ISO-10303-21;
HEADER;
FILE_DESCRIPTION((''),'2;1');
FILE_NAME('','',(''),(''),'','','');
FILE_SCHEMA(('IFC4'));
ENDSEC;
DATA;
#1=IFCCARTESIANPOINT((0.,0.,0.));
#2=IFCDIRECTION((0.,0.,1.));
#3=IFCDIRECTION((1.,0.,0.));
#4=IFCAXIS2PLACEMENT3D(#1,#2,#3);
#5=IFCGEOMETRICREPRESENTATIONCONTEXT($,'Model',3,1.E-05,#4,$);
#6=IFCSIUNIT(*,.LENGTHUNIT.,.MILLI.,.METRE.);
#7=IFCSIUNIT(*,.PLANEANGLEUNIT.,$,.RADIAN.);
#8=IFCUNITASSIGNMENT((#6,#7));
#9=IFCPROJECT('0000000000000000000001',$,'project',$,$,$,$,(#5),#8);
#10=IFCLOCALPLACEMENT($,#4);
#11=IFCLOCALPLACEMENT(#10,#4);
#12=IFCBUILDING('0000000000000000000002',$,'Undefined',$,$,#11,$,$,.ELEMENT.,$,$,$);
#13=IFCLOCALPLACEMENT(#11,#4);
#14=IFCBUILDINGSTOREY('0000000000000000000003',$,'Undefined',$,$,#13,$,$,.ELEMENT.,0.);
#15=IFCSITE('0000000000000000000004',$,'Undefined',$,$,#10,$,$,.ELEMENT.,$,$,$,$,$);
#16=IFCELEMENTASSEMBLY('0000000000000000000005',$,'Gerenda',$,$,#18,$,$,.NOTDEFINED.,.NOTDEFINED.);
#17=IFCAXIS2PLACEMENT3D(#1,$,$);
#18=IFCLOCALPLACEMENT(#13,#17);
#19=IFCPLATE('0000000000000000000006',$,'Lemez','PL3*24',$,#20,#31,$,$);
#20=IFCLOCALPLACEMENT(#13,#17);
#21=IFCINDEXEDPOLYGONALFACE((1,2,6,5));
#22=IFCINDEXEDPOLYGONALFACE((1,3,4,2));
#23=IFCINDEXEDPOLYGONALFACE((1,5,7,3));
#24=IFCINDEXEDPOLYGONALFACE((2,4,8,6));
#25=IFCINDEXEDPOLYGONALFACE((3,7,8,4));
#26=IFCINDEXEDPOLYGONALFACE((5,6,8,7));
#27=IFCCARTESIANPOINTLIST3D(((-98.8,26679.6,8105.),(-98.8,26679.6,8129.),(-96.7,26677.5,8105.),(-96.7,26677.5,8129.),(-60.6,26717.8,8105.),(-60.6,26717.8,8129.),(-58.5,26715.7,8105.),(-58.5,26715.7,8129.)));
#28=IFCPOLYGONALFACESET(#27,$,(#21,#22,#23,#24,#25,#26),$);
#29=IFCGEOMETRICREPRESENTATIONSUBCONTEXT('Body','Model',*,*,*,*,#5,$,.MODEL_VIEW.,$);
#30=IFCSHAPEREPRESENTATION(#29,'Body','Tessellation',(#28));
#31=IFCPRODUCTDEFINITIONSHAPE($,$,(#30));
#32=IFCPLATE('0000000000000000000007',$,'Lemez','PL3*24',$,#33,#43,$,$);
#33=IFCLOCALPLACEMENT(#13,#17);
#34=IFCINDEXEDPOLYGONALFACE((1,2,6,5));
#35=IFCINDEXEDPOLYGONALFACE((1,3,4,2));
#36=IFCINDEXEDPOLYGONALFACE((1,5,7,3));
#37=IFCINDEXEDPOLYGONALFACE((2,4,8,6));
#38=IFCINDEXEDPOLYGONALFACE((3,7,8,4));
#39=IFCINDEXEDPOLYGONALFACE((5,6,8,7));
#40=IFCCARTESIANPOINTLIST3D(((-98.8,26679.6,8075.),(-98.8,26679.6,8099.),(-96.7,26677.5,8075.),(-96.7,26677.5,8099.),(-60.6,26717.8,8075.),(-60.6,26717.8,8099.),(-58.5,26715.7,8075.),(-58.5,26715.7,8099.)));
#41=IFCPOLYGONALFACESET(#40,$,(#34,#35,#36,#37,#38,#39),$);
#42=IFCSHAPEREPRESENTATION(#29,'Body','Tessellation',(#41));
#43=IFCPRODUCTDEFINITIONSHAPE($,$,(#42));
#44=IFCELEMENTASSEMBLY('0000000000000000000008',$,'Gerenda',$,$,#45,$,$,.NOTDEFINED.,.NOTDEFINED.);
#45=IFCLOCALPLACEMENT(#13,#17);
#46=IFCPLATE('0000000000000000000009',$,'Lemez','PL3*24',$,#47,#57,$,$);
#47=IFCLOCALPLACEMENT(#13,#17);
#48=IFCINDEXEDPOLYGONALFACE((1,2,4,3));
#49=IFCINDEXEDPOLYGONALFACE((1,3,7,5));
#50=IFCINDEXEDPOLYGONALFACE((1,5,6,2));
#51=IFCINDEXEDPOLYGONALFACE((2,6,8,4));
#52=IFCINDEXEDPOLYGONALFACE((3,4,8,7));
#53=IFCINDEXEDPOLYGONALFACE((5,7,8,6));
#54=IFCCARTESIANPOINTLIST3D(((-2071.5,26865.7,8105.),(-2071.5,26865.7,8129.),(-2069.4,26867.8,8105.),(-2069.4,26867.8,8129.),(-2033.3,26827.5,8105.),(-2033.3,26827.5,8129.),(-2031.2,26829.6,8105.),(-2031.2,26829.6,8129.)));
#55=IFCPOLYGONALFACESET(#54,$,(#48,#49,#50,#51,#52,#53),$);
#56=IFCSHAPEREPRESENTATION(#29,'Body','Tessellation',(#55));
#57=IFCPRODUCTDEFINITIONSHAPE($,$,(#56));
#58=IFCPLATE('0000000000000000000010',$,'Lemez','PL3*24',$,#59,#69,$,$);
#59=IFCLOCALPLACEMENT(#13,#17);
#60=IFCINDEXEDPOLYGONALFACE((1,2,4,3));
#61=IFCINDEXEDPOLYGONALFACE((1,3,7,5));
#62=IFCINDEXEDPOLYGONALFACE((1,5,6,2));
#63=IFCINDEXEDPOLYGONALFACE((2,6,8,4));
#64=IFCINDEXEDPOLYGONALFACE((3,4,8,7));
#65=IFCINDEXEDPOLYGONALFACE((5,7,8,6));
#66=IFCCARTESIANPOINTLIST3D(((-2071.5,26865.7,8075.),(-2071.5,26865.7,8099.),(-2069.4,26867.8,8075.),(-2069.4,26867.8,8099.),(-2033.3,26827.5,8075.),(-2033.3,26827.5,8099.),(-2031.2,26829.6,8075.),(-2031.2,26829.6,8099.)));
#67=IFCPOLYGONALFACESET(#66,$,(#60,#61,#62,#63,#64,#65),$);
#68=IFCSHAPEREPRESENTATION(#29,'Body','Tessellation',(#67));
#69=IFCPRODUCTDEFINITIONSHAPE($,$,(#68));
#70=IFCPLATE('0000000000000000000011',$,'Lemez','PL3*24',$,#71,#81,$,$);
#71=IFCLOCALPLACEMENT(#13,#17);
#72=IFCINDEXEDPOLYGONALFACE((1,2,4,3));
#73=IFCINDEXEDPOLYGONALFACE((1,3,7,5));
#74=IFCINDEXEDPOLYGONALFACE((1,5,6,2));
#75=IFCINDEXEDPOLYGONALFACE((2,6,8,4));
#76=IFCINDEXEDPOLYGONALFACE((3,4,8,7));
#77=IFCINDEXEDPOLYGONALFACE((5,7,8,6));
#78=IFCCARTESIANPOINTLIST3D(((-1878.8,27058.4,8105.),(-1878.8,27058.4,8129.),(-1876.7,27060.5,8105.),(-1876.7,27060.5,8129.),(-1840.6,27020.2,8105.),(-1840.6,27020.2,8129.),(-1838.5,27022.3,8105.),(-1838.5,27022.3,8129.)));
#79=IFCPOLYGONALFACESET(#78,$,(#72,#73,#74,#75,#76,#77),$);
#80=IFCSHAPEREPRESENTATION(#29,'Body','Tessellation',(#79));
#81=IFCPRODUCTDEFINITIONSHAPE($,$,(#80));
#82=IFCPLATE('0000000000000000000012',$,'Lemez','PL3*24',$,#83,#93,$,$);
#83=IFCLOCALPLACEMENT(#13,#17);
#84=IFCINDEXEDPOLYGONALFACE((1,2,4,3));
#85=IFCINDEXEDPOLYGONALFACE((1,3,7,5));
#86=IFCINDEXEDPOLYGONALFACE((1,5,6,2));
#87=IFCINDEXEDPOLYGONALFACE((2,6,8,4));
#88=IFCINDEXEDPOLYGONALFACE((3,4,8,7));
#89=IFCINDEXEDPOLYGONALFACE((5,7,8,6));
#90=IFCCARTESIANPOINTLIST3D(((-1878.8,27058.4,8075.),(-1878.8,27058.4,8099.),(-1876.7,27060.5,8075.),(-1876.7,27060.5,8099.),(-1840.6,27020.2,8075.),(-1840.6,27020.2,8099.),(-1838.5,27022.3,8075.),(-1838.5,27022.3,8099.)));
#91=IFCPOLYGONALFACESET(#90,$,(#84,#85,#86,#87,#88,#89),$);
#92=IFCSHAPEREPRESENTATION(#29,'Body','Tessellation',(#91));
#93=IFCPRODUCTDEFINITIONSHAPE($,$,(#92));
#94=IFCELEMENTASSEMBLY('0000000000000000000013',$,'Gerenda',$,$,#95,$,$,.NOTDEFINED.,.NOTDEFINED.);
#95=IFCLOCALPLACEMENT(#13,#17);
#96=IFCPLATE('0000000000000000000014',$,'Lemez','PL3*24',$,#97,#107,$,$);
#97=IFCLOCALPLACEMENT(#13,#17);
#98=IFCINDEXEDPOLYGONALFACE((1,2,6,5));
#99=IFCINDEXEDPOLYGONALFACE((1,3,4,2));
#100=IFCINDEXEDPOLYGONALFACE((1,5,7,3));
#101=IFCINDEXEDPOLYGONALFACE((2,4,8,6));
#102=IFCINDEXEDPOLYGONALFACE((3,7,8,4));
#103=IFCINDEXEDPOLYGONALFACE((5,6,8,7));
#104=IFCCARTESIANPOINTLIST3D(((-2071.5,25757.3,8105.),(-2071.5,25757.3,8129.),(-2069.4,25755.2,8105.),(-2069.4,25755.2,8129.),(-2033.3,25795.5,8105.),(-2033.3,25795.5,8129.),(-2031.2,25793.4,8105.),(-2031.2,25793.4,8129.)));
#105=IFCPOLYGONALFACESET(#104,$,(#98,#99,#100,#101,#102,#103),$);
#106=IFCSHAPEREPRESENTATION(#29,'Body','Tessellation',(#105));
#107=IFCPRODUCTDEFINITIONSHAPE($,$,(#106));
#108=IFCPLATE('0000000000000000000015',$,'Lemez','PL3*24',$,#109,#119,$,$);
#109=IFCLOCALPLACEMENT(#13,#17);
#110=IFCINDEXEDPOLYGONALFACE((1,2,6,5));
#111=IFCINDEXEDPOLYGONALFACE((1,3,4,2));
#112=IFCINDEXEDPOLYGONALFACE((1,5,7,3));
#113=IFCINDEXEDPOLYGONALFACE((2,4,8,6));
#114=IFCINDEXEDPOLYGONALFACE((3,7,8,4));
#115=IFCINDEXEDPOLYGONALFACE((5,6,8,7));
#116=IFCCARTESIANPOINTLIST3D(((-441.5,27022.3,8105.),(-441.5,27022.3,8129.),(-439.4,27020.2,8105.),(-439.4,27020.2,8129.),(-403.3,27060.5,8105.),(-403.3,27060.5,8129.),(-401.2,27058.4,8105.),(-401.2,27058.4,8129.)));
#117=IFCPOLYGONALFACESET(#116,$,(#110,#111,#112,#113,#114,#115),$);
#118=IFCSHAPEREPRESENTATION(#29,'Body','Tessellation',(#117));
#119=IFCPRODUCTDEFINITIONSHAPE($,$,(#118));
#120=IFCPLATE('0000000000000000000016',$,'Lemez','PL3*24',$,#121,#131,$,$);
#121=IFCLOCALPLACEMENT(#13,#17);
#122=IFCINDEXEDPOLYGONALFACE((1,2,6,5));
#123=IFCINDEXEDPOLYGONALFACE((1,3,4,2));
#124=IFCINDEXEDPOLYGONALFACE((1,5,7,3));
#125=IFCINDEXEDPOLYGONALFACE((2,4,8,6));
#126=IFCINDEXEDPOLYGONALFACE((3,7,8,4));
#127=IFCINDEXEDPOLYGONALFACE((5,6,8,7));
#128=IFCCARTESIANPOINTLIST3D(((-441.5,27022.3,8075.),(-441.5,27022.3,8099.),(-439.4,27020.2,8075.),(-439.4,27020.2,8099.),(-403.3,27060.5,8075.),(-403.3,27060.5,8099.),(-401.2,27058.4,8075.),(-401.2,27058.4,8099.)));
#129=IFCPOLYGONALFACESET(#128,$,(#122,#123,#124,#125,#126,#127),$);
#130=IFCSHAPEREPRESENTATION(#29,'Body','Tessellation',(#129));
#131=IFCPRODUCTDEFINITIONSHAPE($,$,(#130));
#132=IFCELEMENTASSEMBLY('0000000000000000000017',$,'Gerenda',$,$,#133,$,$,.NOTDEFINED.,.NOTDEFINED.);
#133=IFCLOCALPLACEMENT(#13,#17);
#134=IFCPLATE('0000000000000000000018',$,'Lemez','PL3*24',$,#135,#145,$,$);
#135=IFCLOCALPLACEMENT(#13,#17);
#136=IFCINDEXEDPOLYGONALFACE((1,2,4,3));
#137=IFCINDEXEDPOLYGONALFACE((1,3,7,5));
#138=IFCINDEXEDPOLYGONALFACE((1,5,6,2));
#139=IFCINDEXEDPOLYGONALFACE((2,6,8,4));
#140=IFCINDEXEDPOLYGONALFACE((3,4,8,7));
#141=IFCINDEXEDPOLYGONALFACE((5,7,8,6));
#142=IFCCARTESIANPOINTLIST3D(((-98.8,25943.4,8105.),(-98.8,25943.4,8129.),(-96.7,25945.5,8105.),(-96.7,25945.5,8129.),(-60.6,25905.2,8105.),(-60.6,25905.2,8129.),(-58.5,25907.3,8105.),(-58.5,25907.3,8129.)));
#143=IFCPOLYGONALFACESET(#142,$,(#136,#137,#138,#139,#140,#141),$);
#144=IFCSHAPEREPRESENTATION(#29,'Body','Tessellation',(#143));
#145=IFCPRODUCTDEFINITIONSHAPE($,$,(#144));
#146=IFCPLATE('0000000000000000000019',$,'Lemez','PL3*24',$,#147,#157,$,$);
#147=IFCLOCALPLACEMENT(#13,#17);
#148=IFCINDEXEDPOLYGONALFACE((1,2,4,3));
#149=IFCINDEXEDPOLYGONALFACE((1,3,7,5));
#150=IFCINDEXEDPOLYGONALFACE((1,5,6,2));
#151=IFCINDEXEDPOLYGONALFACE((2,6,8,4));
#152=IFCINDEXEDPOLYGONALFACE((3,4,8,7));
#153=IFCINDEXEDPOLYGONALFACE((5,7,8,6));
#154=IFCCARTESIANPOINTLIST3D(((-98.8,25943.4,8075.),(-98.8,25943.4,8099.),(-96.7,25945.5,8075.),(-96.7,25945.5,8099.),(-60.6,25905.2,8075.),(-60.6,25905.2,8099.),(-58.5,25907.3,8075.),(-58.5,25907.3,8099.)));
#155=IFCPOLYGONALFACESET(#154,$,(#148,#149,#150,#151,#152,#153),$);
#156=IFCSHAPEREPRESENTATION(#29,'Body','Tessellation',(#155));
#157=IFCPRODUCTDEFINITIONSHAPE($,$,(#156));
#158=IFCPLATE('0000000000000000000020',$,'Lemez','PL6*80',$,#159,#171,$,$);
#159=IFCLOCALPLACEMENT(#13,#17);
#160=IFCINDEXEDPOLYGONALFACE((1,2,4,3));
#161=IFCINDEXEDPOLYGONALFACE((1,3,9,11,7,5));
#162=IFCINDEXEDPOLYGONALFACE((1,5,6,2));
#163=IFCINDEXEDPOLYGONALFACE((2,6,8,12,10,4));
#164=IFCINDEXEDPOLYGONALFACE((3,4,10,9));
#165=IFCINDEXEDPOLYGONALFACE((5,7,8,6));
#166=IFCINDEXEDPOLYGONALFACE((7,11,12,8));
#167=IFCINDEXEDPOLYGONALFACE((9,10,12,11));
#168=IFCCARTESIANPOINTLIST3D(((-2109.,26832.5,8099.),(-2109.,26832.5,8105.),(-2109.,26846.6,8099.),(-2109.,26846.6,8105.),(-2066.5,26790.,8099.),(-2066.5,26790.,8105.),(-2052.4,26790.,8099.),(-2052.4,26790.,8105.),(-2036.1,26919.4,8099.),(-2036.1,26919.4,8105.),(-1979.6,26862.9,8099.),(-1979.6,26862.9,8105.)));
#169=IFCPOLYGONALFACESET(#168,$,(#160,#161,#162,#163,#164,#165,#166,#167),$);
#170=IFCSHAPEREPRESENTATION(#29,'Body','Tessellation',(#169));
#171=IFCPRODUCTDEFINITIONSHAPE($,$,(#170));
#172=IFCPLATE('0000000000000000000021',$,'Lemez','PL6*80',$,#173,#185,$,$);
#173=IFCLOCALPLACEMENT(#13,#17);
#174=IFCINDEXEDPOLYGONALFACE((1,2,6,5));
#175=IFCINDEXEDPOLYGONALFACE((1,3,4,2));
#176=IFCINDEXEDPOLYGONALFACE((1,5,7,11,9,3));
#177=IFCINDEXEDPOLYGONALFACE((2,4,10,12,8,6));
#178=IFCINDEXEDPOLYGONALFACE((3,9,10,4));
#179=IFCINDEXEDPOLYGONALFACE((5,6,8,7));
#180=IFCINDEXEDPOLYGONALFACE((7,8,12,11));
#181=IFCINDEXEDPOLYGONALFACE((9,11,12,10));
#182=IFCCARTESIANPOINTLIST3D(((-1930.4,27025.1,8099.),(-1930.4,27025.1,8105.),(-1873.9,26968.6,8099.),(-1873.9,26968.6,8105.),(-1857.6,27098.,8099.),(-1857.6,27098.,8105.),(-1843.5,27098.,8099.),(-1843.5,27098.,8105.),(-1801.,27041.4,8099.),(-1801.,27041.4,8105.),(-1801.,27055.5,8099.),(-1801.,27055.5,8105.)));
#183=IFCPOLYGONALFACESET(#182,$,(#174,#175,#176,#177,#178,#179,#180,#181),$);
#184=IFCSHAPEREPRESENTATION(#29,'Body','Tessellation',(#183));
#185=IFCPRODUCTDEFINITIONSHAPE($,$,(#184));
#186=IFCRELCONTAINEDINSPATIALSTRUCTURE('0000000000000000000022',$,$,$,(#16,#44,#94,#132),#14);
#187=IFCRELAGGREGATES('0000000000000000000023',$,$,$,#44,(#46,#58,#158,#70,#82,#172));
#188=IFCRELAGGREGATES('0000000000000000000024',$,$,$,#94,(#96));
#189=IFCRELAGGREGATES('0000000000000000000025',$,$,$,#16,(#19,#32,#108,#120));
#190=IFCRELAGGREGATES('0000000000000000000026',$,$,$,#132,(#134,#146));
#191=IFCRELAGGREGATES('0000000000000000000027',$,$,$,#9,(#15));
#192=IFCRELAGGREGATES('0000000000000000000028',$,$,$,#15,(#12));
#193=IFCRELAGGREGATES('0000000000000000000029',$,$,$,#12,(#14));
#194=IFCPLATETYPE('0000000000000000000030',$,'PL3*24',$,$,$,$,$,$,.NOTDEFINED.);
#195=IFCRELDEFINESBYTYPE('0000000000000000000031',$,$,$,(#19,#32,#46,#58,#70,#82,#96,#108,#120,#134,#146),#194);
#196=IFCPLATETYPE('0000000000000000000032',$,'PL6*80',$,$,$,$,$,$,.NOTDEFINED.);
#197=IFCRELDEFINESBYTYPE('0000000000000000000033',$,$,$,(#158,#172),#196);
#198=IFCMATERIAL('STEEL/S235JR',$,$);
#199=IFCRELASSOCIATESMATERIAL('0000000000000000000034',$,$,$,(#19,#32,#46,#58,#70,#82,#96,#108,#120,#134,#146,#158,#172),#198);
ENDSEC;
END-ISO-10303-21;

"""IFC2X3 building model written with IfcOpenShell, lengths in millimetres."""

from ifc_helpers import new_model, si_unit, frame, origin_with_axes, place, context, subcontext, project, spatial, polyline, outline, extrude, material, type_object, element, aggregate, save


model = new_model("IFC2X3")

# Units and contexts
model_context = context("Model", 3, precision=1e-05, world=origin_with_axes())
body_context = subcontext(model_context, "Body", "Model", "MODEL_VIEW")
ifc_project = project(units=[si_unit("LENGTHUNIT", "METRE", prefix="MILLI"), si_unit("PLANEANGLEUNIT", "RADIAN")], contexts=[model_context])

# Site, building, storey
site_placement = place(None, origin_with_axes())
site = spatial("IfcSite", under=ifc_project, at=site_placement, Name="Undefined", CompositionType="ELEMENT")
building_placement = place(site_placement, origin_with_axes())
building = spatial("IfcBuilding", under=site, at=building_placement, Name="Undefined", CompositionType="ELEMENT")
storey_placement = place(building_placement, origin_with_axes())
storey = spatial("IfcBuildingStorey", under=building, at=storey_placement, Name="Undefined", CompositionType="ELEMENT", Elevation=0.0)

# Element assemblies, plates
assembly_1_placement = place(storey_placement, origin_with_axes())
assembly_1 = element("IfcElementAssembly", 1, at=assembly_1_placement, inside=storey, Name="Gerenda", AssemblyPlace="NOTDEFINED", PredefinedType="NOTDEFINED")
ifc_material_1 = material(Name="STEEL/S235JR")
plate_type_1 = type_object("IfcPlateType", Name="PL3*24", PredefinedType="NOTDEFINED")
plate_1_placement = place(assembly_1_placement, frame((-59.6, 26716.7, 8129.0), z_axis=(-0.707112, 0.707102, 0.0), x_axis=(0.0, 0.0, -1.0)))
plate_1 = element("IfcPlate", 2, at=plate_1_placement, type_object=plate_type_1, material=ifc_material_1, Name="Lemez", Description="PL3*24", context=body_context, shape_type="SweptSolid", body=[
    extrude(outline(polyline([(0.0, 0.0), (24.0, 0.0), (24.0, 54.0), (0.0, 54.0), (0.0, 0.0)])), frame((0.0, 0.0, -1.5), z_axis=(0.0, 0.0, 1.0), x_axis=(1.0, 0.0, 0.0)), (0.0, 0.0, 1.0), 3.0),
])
plate_2_placement = place(assembly_1_placement, frame((-59.6, 26716.7, 8099.0), z_axis=(-0.707112, 0.707102, 0.0), x_axis=(0.0, 0.0, -1.0)))
plate_2 = element("IfcPlate", 3, at=plate_2_placement, type_object=plate_type_1, material=ifc_material_1, Name="Lemez", Description="PL3*24", context=body_context, shape_type="SweptSolid", body=[
    extrude(outline(polyline([(0.0, 0.0), (24.0, 0.0), (24.0, 54.0), (0.0, 54.0), (0.0, 0.0)])), frame((0.0, 0.0, -1.5), z_axis=(0.0, 0.0, 1.0), x_axis=(1.0, 0.0, 0.0)), (0.0, 0.0, 1.0), 3.0),
])
assembly_2_placement = place(storey_placement, origin_with_axes())
assembly_2 = element("IfcElementAssembly", 4, at=assembly_2_placement, inside=storey, Name="Gerenda", AssemblyPlace="NOTDEFINED", PredefinedType="NOTDEFINED")
plate_3_placement = place(assembly_2_placement, frame((-2032.2, 26828.6, 8129.0), z_axis=(0.707112, 0.707102, 0.0), x_axis=(0.0, 0.0, -1.0)))
plate_3 = element("IfcPlate", 5, at=plate_3_placement, type_object=plate_type_1, material=ifc_material_1, Name="Lemez", Description="PL3*24", context=body_context, shape_type="SweptSolid", body=[
    extrude(outline(polyline([(0.0, 0.0), (24.0, 0.0), (24.0, 54.0), (0.0, 54.0), (0.0, 0.0)])), frame((0.0, 0.0, -1.5), z_axis=(0.0, 0.0, 1.0), x_axis=(1.0, 0.0, 0.0)), (0.0, 0.0, 1.0), 3.0),
])
plate_4_placement = place(assembly_2_placement, frame((-2032.2, 26828.6, 8099.0), z_axis=(0.707112, 0.707102, 0.0), x_axis=(0.0, 0.0, -1.0)))
plate_4 = element("IfcPlate", 6, at=plate_4_placement, type_object=plate_type_1, material=ifc_material_1, Name="Lemez", Description="PL3*24", context=body_context, shape_type="SweptSolid", body=[
    extrude(outline(polyline([(0.0, 0.0), (24.0, 0.0), (24.0, 54.0), (0.0, 54.0), (0.0, 0.0)])), frame((0.0, 0.0, -1.5), z_axis=(0.0, 0.0, 1.0), x_axis=(1.0, 0.0, 0.0)), (0.0, 0.0, 1.0), 3.0),
])
plate_5_placement = place(assembly_2_placement, frame((-1877.7, 27059.4, 8129.0), z_axis=(-0.707112, -0.707102, 0.0), x_axis=(0.0, 0.0, -1.0)))
plate_5 = element("IfcPlate", 7, at=plate_5_placement, type_object=plate_type_1, material=ifc_material_1, Name="Lemez", Description="PL3*24", context=body_context, shape_type="SweptSolid", body=[
    extrude(outline(polyline([(0.0, 0.0), (24.0, 0.0), (24.0, 54.0), (0.0, 54.0), (0.0, 0.0)])), frame((0.0, 0.0, -1.5), z_axis=(0.0, 0.0, 1.0), x_axis=(1.0, 0.0, 0.0)), (0.0, 0.0, 1.0), 3.0),
])
plate_6_placement = place(assembly_2_placement, frame((-1877.7, 27059.4, 8099.0), z_axis=(-0.707112, -0.707102, 0.0), x_axis=(0.0, 0.0, -1.0)))
plate_6 = element("IfcPlate", 8, at=plate_6_placement, type_object=plate_type_1, material=ifc_material_1, Name="Lemez", Description="PL3*24", context=body_context, shape_type="SweptSolid", body=[
    extrude(outline(polyline([(0.0, 0.0), (24.0, 0.0), (24.0, 54.0), (0.0, 54.0), (0.0, 0.0)])), frame((0.0, 0.0, -1.5), z_axis=(0.0, 0.0, 1.0), x_axis=(1.0, 0.0, 0.0)), (0.0, 0.0, 1.0), 3.0),
])

# Element assembly, plate
assembly_3_placement = place(storey_placement, origin_with_axes())
assembly_3 = element("IfcElementAssembly", 9, at=assembly_3_placement, inside=storey, Name="Gerenda", AssemblyPlace="NOTDEFINED", PredefinedType="NOTDEFINED")
plate_7_placement = place(assembly_3_placement, frame((-2070.4, 25756.2, 8129.0), z_axis=(0.707112, -0.707102, 0.0), x_axis=(0.0, 0.0, -1.0)))
plate_7 = element("IfcPlate", 10, at=plate_7_placement, type_object=plate_type_1, material=ifc_material_1, Name="Lemez", Description="PL3*24", context=body_context, shape_type="SweptSolid", body=[
    extrude(outline(polyline([(0.0, 0.0), (24.0, 0.0), (24.0, 54.0), (0.0, 54.0), (0.0, 0.0)])), frame((0.0, 0.0, -1.5), z_axis=(0.0, 0.0, 1.0), x_axis=(1.0, 0.0, 0.0)), (0.0, 0.0, 1.0), 3.0),
])

# Plates
plate_8_placement = place(assembly_1_placement, frame((-440.4, 27021.2, 8129.0), z_axis=(0.707112, -0.707102, 0.0), x_axis=(0.0, 0.0, -1.0)))
plate_8 = element("IfcPlate", 11, at=plate_8_placement, type_object=plate_type_1, material=ifc_material_1, Name="Lemez", Description="PL3*24", context=body_context, shape_type="SweptSolid", body=[
    extrude(outline(polyline([(0.0, 0.0), (24.0, 0.0), (24.0, 54.0), (0.0, 54.0), (0.0, 0.0)])), frame((0.0, 0.0, -1.5), z_axis=(0.0, 0.0, 1.0), x_axis=(1.0, 0.0, 0.0)), (0.0, 0.0, 1.0), 3.0),
])
plate_9_placement = place(assembly_1_placement, frame((-440.4, 27021.2, 8099.0), z_axis=(0.707112, -0.707102, 0.0), x_axis=(0.0, 0.0, -1.0)))
plate_9 = element("IfcPlate", 12, at=plate_9_placement, type_object=plate_type_1, material=ifc_material_1, Name="Lemez", Description="PL3*24", context=body_context, shape_type="SweptSolid", body=[
    extrude(outline(polyline([(0.0, 0.0), (24.0, 0.0), (24.0, 54.0), (0.0, 54.0), (0.0, 0.0)])), frame((0.0, 0.0, -1.5), z_axis=(0.0, 0.0, 1.0), x_axis=(1.0, 0.0, 0.0)), (0.0, 0.0, 1.0), 3.0),
])

# Element assembly, plates
assembly_4_placement = place(storey_placement, origin_with_axes())
assembly_4 = element("IfcElementAssembly", 13, at=assembly_4_placement, inside=storey, Name="Gerenda", AssemblyPlace="NOTDEFINED", PredefinedType="NOTDEFINED")
plate_10_placement = place(assembly_4_placement, frame((-97.8, 25944.4, 8129.0), z_axis=(-0.707112, -0.707102, 0.0), x_axis=(0.0, 0.0, -1.0)))
plate_10 = element("IfcPlate", 14, at=plate_10_placement, type_object=plate_type_1, material=ifc_material_1, Name="Lemez", Description="PL3*24", context=body_context, shape_type="SweptSolid", body=[
    extrude(outline(polyline([(0.0, 0.0), (24.0, 0.0), (24.0, 54.0), (0.0, 54.0), (0.0, 0.0)])), frame((0.0, 0.0, -1.5), z_axis=(0.0, 0.0, 1.0), x_axis=(1.0, 0.0, 0.0)), (0.0, 0.0, 1.0), 3.0),
])
plate_11_placement = place(assembly_4_placement, frame((-97.8, 25944.4, 8099.0), z_axis=(-0.707112, -0.707102, 0.0), x_axis=(0.0, 0.0, -1.0)))
plate_11 = element("IfcPlate", 15, at=plate_11_placement, type_object=plate_type_1, material=ifc_material_1, Name="Lemez", Description="PL3*24", context=body_context, shape_type="SweptSolid", body=[
    extrude(outline(polyline([(0.0, 0.0), (24.0, 0.0), (24.0, 54.0), (0.0, 54.0), (0.0, 0.0)])), frame((0.0, 0.0, -1.5), z_axis=(0.0, 0.0, 1.0), x_axis=(1.0, 0.0, 0.0)), (0.0, 0.0, 1.0), 3.0),
])

# Plates
plate_type_2 = type_object("IfcPlateType", Name="PL6*80", PredefinedType="NOTDEFINED")
plate_12_placement = place(assembly_2_placement, frame((-2109.0, 26846.6, 8102.0), z_axis=(0.0, 0.0, 1.0), x_axis=(-0.000007, -1.0, 0.0)))
plate_12 = element("IfcPlate", 16, at=plate_12_placement, type_object=plate_type_2, material=ifc_material_1, Name="Lemez", Description="PL6*80", context=body_context, shape_type="SweptSolid", body=[
    extrude(outline(polyline([(0.0, 0.0), (14.1, 0.0), (56.6, 42.4), (56.6, 56.6), (-16.3, 129.4), (-72.8, 72.8), (0.0, 0.0)])), frame((0.0, 0.0, -3.0), z_axis=(0.0, 0.0, 1.0), x_axis=(1.0, 0.0, 0.0)), (0.0, 0.0, 1.0), 6.0),
])
plate_13_placement = place(assembly_2_placement, frame((-1801.0, 27041.4, 8102.0), z_axis=(0.0, 0.0, 1.0), x_axis=(0.000007, 1.0, 0.0)))
plate_13 = element("IfcPlate", 17, at=plate_13_placement, type_object=plate_type_2, material=ifc_material_1, Name="Lemez", Description="PL6*80", context=body_context, shape_type="SweptSolid", body=[
    extrude(outline(polyline([(0.0, 0.0), (14.1, 0.0), (56.6, 42.4), (56.6, 56.6), (-16.3, 129.4), (-72.8, 72.8), (0.0, 0.0)])), frame((0.0, 0.0, -3.0), z_axis=(0.0, 0.0, 1.0), x_axis=(1.0, 0.0, 0.0)), (0.0, 0.0, 1.0), 6.0),
])

aggregate(assembly_2, [plate_3, plate_4, plate_12, plate_5, plate_6, plate_13])
aggregate(assembly_3, [plate_7])
aggregate(assembly_1, [plate_1, plate_2, plate_8, plate_9])
aggregate(assembly_4, [plate_10, plate_11])

save(model, "model.ifc")
